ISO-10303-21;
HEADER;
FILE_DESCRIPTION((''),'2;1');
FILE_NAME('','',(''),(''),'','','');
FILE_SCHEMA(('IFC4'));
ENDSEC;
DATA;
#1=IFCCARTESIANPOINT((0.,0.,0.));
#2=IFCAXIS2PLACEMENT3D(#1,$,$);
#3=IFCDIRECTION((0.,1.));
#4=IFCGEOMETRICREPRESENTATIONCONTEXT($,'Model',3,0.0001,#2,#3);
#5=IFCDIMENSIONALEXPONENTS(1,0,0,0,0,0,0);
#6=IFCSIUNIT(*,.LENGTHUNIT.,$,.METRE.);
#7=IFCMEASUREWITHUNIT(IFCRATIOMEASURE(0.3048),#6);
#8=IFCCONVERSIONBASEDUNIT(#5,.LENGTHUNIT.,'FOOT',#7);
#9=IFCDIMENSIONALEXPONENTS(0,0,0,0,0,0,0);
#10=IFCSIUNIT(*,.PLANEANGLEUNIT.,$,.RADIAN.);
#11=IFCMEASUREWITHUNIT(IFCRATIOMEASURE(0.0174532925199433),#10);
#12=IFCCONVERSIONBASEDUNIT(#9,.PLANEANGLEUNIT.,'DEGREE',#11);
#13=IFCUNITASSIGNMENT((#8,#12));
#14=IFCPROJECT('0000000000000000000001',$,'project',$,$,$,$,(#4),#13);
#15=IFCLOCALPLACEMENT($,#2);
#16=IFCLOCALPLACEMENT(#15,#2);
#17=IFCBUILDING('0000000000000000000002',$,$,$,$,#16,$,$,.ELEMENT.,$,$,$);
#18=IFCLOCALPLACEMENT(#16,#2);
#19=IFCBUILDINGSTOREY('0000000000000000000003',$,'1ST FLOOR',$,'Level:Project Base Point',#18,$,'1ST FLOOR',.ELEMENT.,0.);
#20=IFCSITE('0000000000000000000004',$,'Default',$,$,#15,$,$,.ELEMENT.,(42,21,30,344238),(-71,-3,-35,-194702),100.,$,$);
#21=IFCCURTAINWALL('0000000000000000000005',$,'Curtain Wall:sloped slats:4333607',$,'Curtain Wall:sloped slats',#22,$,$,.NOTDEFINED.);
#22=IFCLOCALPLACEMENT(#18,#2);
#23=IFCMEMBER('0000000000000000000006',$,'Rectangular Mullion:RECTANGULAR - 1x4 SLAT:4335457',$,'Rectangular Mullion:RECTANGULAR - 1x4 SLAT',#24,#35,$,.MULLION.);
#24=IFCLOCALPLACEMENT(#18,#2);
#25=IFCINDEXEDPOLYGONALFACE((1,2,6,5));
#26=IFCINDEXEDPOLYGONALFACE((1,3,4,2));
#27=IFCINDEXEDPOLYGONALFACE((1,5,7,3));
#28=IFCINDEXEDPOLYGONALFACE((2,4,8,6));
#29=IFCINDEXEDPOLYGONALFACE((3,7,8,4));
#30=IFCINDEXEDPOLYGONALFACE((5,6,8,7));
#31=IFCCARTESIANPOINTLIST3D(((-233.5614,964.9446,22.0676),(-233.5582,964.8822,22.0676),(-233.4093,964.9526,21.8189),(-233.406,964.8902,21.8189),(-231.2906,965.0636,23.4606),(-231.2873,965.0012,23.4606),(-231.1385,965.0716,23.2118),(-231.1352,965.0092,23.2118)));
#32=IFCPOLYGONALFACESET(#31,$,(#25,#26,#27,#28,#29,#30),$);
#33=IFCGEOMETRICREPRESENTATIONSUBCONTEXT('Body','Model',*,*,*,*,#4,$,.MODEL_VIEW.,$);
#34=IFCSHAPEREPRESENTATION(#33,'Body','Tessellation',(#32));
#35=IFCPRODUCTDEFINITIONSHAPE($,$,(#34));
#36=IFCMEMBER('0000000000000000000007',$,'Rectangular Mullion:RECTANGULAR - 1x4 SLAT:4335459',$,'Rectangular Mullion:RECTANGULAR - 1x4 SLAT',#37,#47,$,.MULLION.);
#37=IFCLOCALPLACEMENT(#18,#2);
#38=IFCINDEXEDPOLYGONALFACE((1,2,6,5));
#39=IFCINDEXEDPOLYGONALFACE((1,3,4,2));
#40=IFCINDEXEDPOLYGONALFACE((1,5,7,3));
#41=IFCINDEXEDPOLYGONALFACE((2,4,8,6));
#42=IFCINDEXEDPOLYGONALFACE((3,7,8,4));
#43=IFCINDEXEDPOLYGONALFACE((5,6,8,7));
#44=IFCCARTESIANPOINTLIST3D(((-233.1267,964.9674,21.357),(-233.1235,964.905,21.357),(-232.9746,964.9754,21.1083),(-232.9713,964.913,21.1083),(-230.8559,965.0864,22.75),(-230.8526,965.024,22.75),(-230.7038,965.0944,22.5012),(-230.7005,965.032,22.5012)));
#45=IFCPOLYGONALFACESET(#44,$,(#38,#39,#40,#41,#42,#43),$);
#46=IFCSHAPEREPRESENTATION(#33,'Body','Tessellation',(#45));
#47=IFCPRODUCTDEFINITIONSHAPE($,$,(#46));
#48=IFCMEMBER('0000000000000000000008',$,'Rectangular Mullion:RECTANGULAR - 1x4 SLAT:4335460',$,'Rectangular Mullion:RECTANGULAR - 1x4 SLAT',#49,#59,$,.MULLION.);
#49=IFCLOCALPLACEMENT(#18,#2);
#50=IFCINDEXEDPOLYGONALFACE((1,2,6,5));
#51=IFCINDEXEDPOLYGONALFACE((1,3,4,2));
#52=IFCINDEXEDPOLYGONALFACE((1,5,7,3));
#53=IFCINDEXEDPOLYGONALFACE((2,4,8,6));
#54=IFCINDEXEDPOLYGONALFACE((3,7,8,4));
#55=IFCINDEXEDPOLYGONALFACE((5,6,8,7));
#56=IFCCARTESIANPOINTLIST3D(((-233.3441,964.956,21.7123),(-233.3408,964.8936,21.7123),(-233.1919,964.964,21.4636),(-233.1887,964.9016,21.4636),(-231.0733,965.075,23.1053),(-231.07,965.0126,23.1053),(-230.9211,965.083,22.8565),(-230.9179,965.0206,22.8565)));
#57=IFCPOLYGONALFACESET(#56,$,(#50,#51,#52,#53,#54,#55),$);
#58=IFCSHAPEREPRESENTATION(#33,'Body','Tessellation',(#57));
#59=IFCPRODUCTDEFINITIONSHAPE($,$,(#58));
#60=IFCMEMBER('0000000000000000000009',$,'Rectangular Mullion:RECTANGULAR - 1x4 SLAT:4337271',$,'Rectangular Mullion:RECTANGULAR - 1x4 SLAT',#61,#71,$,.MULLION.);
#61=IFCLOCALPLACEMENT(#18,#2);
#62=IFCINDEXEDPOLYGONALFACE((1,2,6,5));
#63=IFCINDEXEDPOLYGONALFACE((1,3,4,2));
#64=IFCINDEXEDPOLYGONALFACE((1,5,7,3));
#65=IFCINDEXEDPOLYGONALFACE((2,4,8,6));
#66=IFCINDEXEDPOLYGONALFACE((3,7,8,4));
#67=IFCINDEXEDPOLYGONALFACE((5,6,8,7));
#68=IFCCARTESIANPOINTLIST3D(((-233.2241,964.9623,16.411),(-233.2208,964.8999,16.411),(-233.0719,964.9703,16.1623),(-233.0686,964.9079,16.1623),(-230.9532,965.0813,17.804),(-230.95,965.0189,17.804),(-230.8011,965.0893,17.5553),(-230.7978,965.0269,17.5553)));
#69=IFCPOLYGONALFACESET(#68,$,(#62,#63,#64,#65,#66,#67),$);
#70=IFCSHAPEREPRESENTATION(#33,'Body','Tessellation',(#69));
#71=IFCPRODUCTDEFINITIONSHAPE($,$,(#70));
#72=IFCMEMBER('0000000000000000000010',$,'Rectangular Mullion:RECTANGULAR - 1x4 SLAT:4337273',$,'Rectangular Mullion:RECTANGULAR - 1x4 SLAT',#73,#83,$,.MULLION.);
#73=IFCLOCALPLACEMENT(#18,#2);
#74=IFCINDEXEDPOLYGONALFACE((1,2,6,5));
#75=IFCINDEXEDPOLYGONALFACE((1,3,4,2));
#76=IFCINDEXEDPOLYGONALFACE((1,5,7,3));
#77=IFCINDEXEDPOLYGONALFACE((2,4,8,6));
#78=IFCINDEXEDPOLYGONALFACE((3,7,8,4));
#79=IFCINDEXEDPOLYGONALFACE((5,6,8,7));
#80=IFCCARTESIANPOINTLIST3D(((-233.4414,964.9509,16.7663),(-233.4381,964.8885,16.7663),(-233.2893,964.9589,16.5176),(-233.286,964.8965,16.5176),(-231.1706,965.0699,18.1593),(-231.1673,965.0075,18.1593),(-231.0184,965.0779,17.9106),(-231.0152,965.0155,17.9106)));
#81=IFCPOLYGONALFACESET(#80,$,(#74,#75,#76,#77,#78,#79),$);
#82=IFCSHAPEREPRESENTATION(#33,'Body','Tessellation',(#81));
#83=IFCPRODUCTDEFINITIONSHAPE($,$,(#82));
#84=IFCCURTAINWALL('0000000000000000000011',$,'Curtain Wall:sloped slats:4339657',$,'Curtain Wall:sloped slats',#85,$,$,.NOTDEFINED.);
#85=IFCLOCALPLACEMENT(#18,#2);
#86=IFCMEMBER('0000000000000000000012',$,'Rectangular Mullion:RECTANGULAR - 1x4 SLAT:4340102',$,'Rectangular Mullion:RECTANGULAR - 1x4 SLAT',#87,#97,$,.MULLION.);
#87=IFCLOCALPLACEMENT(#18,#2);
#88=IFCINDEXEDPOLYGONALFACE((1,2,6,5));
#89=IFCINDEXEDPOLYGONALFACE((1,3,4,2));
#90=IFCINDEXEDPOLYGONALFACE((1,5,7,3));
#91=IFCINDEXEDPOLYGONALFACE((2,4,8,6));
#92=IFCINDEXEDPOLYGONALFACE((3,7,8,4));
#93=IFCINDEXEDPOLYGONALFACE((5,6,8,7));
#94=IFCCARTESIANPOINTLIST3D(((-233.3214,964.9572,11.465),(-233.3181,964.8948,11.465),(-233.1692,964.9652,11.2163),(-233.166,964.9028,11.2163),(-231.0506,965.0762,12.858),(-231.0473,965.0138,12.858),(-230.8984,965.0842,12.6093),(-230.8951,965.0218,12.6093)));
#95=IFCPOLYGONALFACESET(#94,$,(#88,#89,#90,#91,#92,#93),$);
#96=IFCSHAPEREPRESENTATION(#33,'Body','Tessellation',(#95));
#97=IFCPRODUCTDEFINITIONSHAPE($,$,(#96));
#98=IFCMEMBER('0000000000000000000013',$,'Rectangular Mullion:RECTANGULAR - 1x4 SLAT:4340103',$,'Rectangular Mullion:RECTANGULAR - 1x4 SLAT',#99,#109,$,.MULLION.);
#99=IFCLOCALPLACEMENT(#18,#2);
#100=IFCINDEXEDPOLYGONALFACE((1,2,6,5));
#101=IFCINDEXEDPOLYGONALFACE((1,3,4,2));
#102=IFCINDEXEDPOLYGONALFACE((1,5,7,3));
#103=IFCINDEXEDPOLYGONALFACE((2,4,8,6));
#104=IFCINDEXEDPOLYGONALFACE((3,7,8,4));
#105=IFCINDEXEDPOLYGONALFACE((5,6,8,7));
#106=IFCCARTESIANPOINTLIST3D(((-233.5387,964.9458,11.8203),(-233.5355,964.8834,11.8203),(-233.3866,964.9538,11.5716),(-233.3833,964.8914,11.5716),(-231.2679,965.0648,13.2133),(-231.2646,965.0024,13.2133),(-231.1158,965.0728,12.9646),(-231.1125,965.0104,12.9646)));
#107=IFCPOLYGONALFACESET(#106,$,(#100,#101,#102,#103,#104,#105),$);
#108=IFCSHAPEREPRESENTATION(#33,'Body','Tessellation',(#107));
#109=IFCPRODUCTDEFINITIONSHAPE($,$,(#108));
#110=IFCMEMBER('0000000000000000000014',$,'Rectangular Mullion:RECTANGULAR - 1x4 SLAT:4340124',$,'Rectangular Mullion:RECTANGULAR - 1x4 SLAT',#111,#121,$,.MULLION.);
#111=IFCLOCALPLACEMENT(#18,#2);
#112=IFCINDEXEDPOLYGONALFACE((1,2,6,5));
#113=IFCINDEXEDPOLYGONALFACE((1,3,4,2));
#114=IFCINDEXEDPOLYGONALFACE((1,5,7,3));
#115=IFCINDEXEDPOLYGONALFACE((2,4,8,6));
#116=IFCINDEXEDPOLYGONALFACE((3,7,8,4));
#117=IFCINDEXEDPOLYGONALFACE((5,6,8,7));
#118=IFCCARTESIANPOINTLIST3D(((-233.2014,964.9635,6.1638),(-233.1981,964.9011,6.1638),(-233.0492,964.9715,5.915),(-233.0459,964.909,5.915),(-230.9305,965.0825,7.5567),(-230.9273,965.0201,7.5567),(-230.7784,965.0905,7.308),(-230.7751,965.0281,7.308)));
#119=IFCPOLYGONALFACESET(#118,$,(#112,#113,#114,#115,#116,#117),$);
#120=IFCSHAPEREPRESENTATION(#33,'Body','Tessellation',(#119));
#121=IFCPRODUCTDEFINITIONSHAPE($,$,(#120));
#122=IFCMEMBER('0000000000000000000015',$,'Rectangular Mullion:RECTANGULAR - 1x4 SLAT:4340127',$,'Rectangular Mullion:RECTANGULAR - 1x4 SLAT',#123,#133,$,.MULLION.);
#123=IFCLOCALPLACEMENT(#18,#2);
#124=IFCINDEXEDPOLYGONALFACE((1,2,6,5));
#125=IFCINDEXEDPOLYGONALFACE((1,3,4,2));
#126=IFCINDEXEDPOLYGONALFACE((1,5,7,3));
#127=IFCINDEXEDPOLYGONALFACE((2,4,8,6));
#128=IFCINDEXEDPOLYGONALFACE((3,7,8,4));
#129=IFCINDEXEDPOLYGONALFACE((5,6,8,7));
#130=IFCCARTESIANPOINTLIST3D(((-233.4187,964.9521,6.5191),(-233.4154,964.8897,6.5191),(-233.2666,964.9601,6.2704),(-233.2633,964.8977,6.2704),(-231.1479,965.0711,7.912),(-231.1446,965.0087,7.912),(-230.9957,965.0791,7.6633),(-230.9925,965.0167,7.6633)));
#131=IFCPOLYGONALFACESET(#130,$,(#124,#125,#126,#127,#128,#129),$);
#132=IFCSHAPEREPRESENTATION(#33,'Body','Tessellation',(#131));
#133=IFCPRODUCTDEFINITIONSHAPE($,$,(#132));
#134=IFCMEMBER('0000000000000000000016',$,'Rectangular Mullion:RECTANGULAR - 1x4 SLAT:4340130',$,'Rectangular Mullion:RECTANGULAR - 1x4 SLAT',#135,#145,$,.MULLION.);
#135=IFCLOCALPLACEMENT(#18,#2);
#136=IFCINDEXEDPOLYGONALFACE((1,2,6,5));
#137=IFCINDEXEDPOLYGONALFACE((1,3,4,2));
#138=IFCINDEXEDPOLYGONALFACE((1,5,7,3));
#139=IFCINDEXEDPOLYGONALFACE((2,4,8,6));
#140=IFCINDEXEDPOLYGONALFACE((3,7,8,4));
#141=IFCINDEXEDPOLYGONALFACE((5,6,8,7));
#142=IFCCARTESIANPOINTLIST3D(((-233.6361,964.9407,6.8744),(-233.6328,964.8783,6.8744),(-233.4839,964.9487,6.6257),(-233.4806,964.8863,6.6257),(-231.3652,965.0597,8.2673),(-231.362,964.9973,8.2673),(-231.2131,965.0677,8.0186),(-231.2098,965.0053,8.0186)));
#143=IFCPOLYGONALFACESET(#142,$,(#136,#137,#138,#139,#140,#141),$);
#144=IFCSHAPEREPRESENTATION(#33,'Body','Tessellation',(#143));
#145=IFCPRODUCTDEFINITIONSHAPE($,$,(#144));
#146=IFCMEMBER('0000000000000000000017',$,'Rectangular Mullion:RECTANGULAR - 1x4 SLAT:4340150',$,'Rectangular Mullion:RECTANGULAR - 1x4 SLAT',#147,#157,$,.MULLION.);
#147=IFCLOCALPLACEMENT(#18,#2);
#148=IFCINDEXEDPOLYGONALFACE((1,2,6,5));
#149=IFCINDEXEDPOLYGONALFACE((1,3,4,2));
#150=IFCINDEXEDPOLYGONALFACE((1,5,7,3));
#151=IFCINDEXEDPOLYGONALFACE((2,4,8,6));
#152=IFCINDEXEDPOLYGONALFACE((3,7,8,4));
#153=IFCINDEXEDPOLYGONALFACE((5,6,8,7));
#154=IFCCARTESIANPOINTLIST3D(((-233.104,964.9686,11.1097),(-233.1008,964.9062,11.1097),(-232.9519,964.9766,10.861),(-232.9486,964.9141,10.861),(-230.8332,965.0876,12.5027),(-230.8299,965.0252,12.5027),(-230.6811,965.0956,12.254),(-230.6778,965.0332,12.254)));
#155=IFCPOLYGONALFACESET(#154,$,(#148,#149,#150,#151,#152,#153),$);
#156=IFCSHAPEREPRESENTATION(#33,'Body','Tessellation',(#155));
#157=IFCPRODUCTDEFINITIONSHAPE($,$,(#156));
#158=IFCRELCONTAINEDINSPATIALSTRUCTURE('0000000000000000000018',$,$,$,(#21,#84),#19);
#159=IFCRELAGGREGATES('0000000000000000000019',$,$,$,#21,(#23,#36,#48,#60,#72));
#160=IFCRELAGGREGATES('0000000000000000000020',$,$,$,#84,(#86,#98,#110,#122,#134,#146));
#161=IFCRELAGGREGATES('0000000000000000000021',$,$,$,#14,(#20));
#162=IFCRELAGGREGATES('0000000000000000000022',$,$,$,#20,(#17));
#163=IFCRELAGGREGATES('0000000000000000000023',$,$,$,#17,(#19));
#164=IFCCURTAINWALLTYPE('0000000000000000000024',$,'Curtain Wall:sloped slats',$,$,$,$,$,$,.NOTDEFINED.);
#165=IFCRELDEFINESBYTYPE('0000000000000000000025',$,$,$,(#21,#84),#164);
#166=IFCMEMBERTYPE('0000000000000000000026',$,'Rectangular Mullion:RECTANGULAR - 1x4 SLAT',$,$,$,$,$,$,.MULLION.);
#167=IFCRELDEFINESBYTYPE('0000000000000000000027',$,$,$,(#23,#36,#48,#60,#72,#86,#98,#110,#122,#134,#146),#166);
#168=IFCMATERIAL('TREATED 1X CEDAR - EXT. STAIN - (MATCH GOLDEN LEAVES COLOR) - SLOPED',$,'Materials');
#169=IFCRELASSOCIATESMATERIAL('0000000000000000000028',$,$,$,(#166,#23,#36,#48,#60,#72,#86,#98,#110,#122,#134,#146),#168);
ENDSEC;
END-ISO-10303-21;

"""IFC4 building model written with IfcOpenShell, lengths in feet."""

from ifc_helpers import new_model, entity, si_unit, converted_unit, direction, frame, frame_2d, origin, place, context, subcontext, project, spatial, rectangle, extrude, source, transform, mapped, material, material_profile, profile_set, profile_usage, type_object, type_shapes, element, aggregate, save


model = new_model("IFC4")

# Units and contexts
model_context = context("Model", 3, precision=0.0001, world=origin(), true_north=direction((0.0, 1.0)))
body_context = subcontext(model_context, "Body", "Model", "MODEL_VIEW")
ifc_project = project(units=[converted_unit("LENGTHUNIT", "FOOT", entity("IfcRatioMeasure", 0.3048), si_unit("LENGTHUNIT", "METRE"), dimensions=[1, 0, 0, 0, 0, 0, 0]), converted_unit("PLANEANGLEUNIT", "DEGREE", entity("IfcRatioMeasure", 0.0174532925199433), si_unit("PLANEANGLEUNIT", "RADIAN"), dimensions=[0, 0, 0, 0, 0, 0, 0])], contexts=[model_context])

# Site, building, storey
site_placement = place(None, origin())
site = spatial("IfcSite", under=ifc_project, at=site_placement, Name="Default", CompositionType="ELEMENT", RefLatitude=(42, 21, 30, 344238), RefLongitude=(-71, -3, -35, -194702), RefElevation=100.0)
building_placement = place(site_placement, origin())
building = spatial("IfcBuilding", under=site, at=building_placement, CompositionType="ELEMENT")
storey_placement = place(building_placement, origin())
storey = spatial("IfcBuildingStorey", under=building, at=storey_placement, Name="1ST FLOOR", ObjectType="Level:Project Base Point", LongName="1ST FLOOR", CompositionType="ELEMENT", Elevation=0.0)

# Curtain walls, members
curtain_wall_type_1 = type_object("IfcCurtainWallType", Name="Curtain Wall:sloped slats", PredefinedType="NOTDEFINED")
curtain_wall_1_placement = place(storey_placement, origin())
curtain_wall_1 = element("IfcCurtainWall", 1, at=curtain_wall_1_placement, inside=storey, type_object=curtain_wall_type_1, Name="Curtain Wall:sloped slats:4333607", ObjectType="Curtain Wall:sloped slats", PredefinedType="NOTDEFINED")
ifc_material_1 = material(Name="TREATED 1X CEDAR - EXT. STAIN - (MATCH GOLDEN LEAVES COLOR) - SLOPED", Category="Materials")
ifc_material_profile_1 = material_profile(ifc_material_1, rectangle(XDim=0.0625, YDim=0.2917, at=frame_2d((0.0, 0.0), x_axis=(1.0, 0.0))), Name="RECTANGULAR - 1x4 SLAT")
ifc_profile_set_1 = profile_set([ifc_material_profile_1], Name="RECTANGULAR - 1x4 SLAT")
ifc_profile_usage_1 = profile_usage(ifc_profile_set_1)
member_type_1 = type_object("IfcMemberType", Name="Rectangular Mullion:RECTANGULAR - 1x4 SLAT", PredefinedType="MULLION", material=ifc_profile_set_1)
shared_shape_1 = source(origin(), body_context, "Body", "SweptSolid", [
    extrude(rectangle(XDim=0.0625, YDim=0.2917, at=frame_2d((0.0, 0.0), x_axis=(1.0, 0.0))), frame((0.0, 0.0, -2.6667), z_axis=(0.0, 0.0, 1.0), x_axis=(0.0, -1.0, 0.0)), (0.0, 0.0, 1.0), 2.6667),
])
type_shapes(member_type_1, [shared_shape_1])
member_1_placement = place(storey_placement, frame((-233.4837, 964.9174, 21.9433), z_axis=(-0.851559, -0.044628, -0.522356), x_axis=(-0.52164, -0.027338, 0.852727)))
member_1 = element("IfcMember", 2, at=member_1_placement, type_object=member_type_1, material=ifc_profile_usage_1, Name="Rectangular Mullion:RECTANGULAR - 1x4 SLAT:4335457", ObjectType="Rectangular Mullion:RECTANGULAR - 1x4 SLAT", PredefinedType="MULLION", context=body_context, shape_type="MappedRepresentation", body=[
    mapped(shared_shape_1, transform((0.0, 0.0, 0.0), scale=1.0)),
])
ifc_profile_usage_2 = profile_usage(ifc_profile_set_1)
member_2_placement = place(storey_placement, frame((-233.049, 964.9402, 21.2326), z_axis=(-0.851559, -0.044628, -0.522356), x_axis=(-0.52164, -0.027338, 0.852727)))
member_2 = element("IfcMember", 3, at=member_2_placement, type_object=member_type_1, material=ifc_profile_usage_2, Name="Rectangular Mullion:RECTANGULAR - 1x4 SLAT:4335459", ObjectType="Rectangular Mullion:RECTANGULAR - 1x4 SLAT", PredefinedType="MULLION", context=body_context, shape_type="MappedRepresentation", body=[
    mapped(shared_shape_1, transform((0.0, 0.0, 0.0), scale=1.0)),
])
ifc_profile_usage_3 = profile_usage(ifc_profile_set_1)
member_3_placement = place(storey_placement, frame((-233.2664, 964.9288, 21.588), z_axis=(-0.851559, -0.044628, -0.522356), x_axis=(-0.52164, -0.027338, 0.852727)))
member_3 = element("IfcMember", 4, at=member_3_placement, type_object=member_type_1, material=ifc_profile_usage_3, Name="Rectangular Mullion:RECTANGULAR - 1x4 SLAT:4335460", ObjectType="Rectangular Mullion:RECTANGULAR - 1x4 SLAT", PredefinedType="MULLION", context=body_context, shape_type="MappedRepresentation", body=[
    mapped(shared_shape_1, transform((0.0, 0.0, 0.0), scale=1.0)),
])
ifc_profile_usage_4 = profile_usage(ifc_profile_set_1)
member_4_placement = place(storey_placement, frame((-233.1464, 964.9351, 16.2867), z_axis=(-0.851559, -0.044628, -0.522356), x_axis=(-0.52164, -0.027338, 0.852727)))
member_4 = element("IfcMember", 5, at=member_4_placement, type_object=member_type_1, material=ifc_profile_usage_4, Name="Rectangular Mullion:RECTANGULAR - 1x4 SLAT:4337271", ObjectType="Rectangular Mullion:RECTANGULAR - 1x4 SLAT", PredefinedType="MULLION", context=body_context, shape_type="MappedRepresentation", body=[
    mapped(shared_shape_1, transform((0.0, 0.0, 0.0), scale=1.0)),
])
ifc_profile_usage_5 = profile_usage(ifc_profile_set_1)
member_5_placement = place(storey_placement, frame((-233.3637, 964.9237, 16.642), z_axis=(-0.851559, -0.044628, -0.522356), x_axis=(-0.52164, -0.027338, 0.852727)))
member_5 = element("IfcMember", 6, at=member_5_placement, type_object=member_type_1, material=ifc_profile_usage_5, Name="Rectangular Mullion:RECTANGULAR - 1x4 SLAT:4337273", ObjectType="Rectangular Mullion:RECTANGULAR - 1x4 SLAT", PredefinedType="MULLION", context=body_context, shape_type="MappedRepresentation", body=[
    mapped(shared_shape_1, transform((0.0, 0.0, 0.0), scale=1.0)),
])
aggregate(curtain_wall_1, [member_1, member_2, member_3, member_4, member_5])
curtain_wall_2_placement = place(storey_placement, origin())
curtain_wall_2 = element("IfcCurtainWall", 7, at=curtain_wall_2_placement, inside=storey, type_object=curtain_wall_type_1, Name="Curtain Wall:sloped slats:4339657", ObjectType="Curtain Wall:sloped slats", PredefinedType="NOTDEFINED")
ifc_profile_usage_6 = profile_usage(ifc_profile_set_1)
member_6_placement = place(storey_placement, frame((-233.2437, 964.93, 11.3407), z_axis=(-0.851559, -0.044628, -0.522356), x_axis=(-0.52164, -0.027338, 0.852727)))
member_6 = element("IfcMember", 8, at=member_6_placement, type_object=member_type_1, material=ifc_profile_usage_6, Name="Rectangular Mullion:RECTANGULAR - 1x4 SLAT:4340102", ObjectType="Rectangular Mullion:RECTANGULAR - 1x4 SLAT", PredefinedType="MULLION", context=body_context, shape_type="MappedRepresentation", body=[
    mapped(shared_shape_1, transform((0.0, 0.0, 0.0), scale=1.0)),
])
ifc_profile_usage_7 = profile_usage(ifc_profile_set_1)
member_7_placement = place(storey_placement, frame((-233.461, 964.9186, 11.696), z_axis=(-0.851559, -0.044628, -0.522356), x_axis=(-0.52164, -0.027338, 0.852727)))
member_7 = element("IfcMember", 9, at=member_7_placement, type_object=member_type_1, material=ifc_profile_usage_7, Name="Rectangular Mullion:RECTANGULAR - 1x4 SLAT:4340103", ObjectType="Rectangular Mullion:RECTANGULAR - 1x4 SLAT", PredefinedType="MULLION", context=body_context, shape_type="MappedRepresentation", body=[
    mapped(shared_shape_1, transform((0.0, 0.0, 0.0), scale=1.0)),
])
ifc_profile_usage_8 = profile_usage(ifc_profile_set_1)
member_8_placement = place(storey_placement, frame((-233.1237, 964.9363, 6.0394), z_axis=(-0.851559, -0.044628, -0.522356), x_axis=(-0.52164, -0.027338, 0.852727)))
member_8 = element("IfcMember", 10, at=member_8_placement, type_object=member_type_1, material=ifc_profile_usage_8, Name="Rectangular Mullion:RECTANGULAR - 1x4 SLAT:4340124", ObjectType="Rectangular Mullion:RECTANGULAR - 1x4 SLAT", PredefinedType="MULLION", context=body_context, shape_type="MappedRepresentation", body=[
    mapped(shared_shape_1, transform((0.0, 0.0, 0.0), scale=1.0)),
])
ifc_profile_usage_9 = profile_usage(ifc_profile_set_1)
member_9_placement = place(storey_placement, frame((-233.341, 964.9249, 6.3947), z_axis=(-0.851559, -0.044628, -0.522356), x_axis=(-0.52164, -0.027338, 0.852727)))
member_9 = element("IfcMember", 11, at=member_9_placement, type_object=member_type_1, material=ifc_profile_usage_9, Name="Rectangular Mullion:RECTANGULAR - 1x4 SLAT:4340127", ObjectType="Rectangular Mullion:RECTANGULAR - 1x4 SLAT", PredefinedType="MULLION", context=body_context, shape_type="MappedRepresentation", body=[
    mapped(shared_shape_1, transform((0.0, 0.0, 0.0), scale=1.0)),
])
ifc_profile_usage_10 = profile_usage(ifc_profile_set_1)
member_10_placement = place(storey_placement, frame((-233.5584, 964.9135, 6.75), z_axis=(-0.851559, -0.044628, -0.522356), x_axis=(-0.52164, -0.027338, 0.852727)))
member_10 = element("IfcMember", 12, at=member_10_placement, type_object=member_type_1, material=ifc_profile_usage_10, Name="Rectangular Mullion:RECTANGULAR - 1x4 SLAT:4340130", ObjectType="Rectangular Mullion:RECTANGULAR - 1x4 SLAT", PredefinedType="MULLION", context=body_context, shape_type="MappedRepresentation", body=[
    mapped(shared_shape_1, transform((0.0, 0.0, 0.0), scale=1.0)),
])
ifc_profile_usage_11 = profile_usage(ifc_profile_set_1)
member_11_placement = place(storey_placement, frame((-233.0263, 964.9414, 10.9854), z_axis=(-0.851559, -0.044628, -0.522356), x_axis=(-0.52164, -0.027338, 0.852727)))
member_11 = element("IfcMember", 13, at=member_11_placement, type_object=member_type_1, material=ifc_profile_usage_11, Name="Rectangular Mullion:RECTANGULAR - 1x4 SLAT:4340150", ObjectType="Rectangular Mullion:RECTANGULAR - 1x4 SLAT", PredefinedType="MULLION", context=body_context, shape_type="MappedRepresentation", body=[
    mapped(shared_shape_1, transform((0.0, 0.0, 0.0), scale=1.0)),
])
aggregate(curtain_wall_2, [member_6, member_7, member_8, member_9, member_10, member_11])

save(model, "model.ifc")
